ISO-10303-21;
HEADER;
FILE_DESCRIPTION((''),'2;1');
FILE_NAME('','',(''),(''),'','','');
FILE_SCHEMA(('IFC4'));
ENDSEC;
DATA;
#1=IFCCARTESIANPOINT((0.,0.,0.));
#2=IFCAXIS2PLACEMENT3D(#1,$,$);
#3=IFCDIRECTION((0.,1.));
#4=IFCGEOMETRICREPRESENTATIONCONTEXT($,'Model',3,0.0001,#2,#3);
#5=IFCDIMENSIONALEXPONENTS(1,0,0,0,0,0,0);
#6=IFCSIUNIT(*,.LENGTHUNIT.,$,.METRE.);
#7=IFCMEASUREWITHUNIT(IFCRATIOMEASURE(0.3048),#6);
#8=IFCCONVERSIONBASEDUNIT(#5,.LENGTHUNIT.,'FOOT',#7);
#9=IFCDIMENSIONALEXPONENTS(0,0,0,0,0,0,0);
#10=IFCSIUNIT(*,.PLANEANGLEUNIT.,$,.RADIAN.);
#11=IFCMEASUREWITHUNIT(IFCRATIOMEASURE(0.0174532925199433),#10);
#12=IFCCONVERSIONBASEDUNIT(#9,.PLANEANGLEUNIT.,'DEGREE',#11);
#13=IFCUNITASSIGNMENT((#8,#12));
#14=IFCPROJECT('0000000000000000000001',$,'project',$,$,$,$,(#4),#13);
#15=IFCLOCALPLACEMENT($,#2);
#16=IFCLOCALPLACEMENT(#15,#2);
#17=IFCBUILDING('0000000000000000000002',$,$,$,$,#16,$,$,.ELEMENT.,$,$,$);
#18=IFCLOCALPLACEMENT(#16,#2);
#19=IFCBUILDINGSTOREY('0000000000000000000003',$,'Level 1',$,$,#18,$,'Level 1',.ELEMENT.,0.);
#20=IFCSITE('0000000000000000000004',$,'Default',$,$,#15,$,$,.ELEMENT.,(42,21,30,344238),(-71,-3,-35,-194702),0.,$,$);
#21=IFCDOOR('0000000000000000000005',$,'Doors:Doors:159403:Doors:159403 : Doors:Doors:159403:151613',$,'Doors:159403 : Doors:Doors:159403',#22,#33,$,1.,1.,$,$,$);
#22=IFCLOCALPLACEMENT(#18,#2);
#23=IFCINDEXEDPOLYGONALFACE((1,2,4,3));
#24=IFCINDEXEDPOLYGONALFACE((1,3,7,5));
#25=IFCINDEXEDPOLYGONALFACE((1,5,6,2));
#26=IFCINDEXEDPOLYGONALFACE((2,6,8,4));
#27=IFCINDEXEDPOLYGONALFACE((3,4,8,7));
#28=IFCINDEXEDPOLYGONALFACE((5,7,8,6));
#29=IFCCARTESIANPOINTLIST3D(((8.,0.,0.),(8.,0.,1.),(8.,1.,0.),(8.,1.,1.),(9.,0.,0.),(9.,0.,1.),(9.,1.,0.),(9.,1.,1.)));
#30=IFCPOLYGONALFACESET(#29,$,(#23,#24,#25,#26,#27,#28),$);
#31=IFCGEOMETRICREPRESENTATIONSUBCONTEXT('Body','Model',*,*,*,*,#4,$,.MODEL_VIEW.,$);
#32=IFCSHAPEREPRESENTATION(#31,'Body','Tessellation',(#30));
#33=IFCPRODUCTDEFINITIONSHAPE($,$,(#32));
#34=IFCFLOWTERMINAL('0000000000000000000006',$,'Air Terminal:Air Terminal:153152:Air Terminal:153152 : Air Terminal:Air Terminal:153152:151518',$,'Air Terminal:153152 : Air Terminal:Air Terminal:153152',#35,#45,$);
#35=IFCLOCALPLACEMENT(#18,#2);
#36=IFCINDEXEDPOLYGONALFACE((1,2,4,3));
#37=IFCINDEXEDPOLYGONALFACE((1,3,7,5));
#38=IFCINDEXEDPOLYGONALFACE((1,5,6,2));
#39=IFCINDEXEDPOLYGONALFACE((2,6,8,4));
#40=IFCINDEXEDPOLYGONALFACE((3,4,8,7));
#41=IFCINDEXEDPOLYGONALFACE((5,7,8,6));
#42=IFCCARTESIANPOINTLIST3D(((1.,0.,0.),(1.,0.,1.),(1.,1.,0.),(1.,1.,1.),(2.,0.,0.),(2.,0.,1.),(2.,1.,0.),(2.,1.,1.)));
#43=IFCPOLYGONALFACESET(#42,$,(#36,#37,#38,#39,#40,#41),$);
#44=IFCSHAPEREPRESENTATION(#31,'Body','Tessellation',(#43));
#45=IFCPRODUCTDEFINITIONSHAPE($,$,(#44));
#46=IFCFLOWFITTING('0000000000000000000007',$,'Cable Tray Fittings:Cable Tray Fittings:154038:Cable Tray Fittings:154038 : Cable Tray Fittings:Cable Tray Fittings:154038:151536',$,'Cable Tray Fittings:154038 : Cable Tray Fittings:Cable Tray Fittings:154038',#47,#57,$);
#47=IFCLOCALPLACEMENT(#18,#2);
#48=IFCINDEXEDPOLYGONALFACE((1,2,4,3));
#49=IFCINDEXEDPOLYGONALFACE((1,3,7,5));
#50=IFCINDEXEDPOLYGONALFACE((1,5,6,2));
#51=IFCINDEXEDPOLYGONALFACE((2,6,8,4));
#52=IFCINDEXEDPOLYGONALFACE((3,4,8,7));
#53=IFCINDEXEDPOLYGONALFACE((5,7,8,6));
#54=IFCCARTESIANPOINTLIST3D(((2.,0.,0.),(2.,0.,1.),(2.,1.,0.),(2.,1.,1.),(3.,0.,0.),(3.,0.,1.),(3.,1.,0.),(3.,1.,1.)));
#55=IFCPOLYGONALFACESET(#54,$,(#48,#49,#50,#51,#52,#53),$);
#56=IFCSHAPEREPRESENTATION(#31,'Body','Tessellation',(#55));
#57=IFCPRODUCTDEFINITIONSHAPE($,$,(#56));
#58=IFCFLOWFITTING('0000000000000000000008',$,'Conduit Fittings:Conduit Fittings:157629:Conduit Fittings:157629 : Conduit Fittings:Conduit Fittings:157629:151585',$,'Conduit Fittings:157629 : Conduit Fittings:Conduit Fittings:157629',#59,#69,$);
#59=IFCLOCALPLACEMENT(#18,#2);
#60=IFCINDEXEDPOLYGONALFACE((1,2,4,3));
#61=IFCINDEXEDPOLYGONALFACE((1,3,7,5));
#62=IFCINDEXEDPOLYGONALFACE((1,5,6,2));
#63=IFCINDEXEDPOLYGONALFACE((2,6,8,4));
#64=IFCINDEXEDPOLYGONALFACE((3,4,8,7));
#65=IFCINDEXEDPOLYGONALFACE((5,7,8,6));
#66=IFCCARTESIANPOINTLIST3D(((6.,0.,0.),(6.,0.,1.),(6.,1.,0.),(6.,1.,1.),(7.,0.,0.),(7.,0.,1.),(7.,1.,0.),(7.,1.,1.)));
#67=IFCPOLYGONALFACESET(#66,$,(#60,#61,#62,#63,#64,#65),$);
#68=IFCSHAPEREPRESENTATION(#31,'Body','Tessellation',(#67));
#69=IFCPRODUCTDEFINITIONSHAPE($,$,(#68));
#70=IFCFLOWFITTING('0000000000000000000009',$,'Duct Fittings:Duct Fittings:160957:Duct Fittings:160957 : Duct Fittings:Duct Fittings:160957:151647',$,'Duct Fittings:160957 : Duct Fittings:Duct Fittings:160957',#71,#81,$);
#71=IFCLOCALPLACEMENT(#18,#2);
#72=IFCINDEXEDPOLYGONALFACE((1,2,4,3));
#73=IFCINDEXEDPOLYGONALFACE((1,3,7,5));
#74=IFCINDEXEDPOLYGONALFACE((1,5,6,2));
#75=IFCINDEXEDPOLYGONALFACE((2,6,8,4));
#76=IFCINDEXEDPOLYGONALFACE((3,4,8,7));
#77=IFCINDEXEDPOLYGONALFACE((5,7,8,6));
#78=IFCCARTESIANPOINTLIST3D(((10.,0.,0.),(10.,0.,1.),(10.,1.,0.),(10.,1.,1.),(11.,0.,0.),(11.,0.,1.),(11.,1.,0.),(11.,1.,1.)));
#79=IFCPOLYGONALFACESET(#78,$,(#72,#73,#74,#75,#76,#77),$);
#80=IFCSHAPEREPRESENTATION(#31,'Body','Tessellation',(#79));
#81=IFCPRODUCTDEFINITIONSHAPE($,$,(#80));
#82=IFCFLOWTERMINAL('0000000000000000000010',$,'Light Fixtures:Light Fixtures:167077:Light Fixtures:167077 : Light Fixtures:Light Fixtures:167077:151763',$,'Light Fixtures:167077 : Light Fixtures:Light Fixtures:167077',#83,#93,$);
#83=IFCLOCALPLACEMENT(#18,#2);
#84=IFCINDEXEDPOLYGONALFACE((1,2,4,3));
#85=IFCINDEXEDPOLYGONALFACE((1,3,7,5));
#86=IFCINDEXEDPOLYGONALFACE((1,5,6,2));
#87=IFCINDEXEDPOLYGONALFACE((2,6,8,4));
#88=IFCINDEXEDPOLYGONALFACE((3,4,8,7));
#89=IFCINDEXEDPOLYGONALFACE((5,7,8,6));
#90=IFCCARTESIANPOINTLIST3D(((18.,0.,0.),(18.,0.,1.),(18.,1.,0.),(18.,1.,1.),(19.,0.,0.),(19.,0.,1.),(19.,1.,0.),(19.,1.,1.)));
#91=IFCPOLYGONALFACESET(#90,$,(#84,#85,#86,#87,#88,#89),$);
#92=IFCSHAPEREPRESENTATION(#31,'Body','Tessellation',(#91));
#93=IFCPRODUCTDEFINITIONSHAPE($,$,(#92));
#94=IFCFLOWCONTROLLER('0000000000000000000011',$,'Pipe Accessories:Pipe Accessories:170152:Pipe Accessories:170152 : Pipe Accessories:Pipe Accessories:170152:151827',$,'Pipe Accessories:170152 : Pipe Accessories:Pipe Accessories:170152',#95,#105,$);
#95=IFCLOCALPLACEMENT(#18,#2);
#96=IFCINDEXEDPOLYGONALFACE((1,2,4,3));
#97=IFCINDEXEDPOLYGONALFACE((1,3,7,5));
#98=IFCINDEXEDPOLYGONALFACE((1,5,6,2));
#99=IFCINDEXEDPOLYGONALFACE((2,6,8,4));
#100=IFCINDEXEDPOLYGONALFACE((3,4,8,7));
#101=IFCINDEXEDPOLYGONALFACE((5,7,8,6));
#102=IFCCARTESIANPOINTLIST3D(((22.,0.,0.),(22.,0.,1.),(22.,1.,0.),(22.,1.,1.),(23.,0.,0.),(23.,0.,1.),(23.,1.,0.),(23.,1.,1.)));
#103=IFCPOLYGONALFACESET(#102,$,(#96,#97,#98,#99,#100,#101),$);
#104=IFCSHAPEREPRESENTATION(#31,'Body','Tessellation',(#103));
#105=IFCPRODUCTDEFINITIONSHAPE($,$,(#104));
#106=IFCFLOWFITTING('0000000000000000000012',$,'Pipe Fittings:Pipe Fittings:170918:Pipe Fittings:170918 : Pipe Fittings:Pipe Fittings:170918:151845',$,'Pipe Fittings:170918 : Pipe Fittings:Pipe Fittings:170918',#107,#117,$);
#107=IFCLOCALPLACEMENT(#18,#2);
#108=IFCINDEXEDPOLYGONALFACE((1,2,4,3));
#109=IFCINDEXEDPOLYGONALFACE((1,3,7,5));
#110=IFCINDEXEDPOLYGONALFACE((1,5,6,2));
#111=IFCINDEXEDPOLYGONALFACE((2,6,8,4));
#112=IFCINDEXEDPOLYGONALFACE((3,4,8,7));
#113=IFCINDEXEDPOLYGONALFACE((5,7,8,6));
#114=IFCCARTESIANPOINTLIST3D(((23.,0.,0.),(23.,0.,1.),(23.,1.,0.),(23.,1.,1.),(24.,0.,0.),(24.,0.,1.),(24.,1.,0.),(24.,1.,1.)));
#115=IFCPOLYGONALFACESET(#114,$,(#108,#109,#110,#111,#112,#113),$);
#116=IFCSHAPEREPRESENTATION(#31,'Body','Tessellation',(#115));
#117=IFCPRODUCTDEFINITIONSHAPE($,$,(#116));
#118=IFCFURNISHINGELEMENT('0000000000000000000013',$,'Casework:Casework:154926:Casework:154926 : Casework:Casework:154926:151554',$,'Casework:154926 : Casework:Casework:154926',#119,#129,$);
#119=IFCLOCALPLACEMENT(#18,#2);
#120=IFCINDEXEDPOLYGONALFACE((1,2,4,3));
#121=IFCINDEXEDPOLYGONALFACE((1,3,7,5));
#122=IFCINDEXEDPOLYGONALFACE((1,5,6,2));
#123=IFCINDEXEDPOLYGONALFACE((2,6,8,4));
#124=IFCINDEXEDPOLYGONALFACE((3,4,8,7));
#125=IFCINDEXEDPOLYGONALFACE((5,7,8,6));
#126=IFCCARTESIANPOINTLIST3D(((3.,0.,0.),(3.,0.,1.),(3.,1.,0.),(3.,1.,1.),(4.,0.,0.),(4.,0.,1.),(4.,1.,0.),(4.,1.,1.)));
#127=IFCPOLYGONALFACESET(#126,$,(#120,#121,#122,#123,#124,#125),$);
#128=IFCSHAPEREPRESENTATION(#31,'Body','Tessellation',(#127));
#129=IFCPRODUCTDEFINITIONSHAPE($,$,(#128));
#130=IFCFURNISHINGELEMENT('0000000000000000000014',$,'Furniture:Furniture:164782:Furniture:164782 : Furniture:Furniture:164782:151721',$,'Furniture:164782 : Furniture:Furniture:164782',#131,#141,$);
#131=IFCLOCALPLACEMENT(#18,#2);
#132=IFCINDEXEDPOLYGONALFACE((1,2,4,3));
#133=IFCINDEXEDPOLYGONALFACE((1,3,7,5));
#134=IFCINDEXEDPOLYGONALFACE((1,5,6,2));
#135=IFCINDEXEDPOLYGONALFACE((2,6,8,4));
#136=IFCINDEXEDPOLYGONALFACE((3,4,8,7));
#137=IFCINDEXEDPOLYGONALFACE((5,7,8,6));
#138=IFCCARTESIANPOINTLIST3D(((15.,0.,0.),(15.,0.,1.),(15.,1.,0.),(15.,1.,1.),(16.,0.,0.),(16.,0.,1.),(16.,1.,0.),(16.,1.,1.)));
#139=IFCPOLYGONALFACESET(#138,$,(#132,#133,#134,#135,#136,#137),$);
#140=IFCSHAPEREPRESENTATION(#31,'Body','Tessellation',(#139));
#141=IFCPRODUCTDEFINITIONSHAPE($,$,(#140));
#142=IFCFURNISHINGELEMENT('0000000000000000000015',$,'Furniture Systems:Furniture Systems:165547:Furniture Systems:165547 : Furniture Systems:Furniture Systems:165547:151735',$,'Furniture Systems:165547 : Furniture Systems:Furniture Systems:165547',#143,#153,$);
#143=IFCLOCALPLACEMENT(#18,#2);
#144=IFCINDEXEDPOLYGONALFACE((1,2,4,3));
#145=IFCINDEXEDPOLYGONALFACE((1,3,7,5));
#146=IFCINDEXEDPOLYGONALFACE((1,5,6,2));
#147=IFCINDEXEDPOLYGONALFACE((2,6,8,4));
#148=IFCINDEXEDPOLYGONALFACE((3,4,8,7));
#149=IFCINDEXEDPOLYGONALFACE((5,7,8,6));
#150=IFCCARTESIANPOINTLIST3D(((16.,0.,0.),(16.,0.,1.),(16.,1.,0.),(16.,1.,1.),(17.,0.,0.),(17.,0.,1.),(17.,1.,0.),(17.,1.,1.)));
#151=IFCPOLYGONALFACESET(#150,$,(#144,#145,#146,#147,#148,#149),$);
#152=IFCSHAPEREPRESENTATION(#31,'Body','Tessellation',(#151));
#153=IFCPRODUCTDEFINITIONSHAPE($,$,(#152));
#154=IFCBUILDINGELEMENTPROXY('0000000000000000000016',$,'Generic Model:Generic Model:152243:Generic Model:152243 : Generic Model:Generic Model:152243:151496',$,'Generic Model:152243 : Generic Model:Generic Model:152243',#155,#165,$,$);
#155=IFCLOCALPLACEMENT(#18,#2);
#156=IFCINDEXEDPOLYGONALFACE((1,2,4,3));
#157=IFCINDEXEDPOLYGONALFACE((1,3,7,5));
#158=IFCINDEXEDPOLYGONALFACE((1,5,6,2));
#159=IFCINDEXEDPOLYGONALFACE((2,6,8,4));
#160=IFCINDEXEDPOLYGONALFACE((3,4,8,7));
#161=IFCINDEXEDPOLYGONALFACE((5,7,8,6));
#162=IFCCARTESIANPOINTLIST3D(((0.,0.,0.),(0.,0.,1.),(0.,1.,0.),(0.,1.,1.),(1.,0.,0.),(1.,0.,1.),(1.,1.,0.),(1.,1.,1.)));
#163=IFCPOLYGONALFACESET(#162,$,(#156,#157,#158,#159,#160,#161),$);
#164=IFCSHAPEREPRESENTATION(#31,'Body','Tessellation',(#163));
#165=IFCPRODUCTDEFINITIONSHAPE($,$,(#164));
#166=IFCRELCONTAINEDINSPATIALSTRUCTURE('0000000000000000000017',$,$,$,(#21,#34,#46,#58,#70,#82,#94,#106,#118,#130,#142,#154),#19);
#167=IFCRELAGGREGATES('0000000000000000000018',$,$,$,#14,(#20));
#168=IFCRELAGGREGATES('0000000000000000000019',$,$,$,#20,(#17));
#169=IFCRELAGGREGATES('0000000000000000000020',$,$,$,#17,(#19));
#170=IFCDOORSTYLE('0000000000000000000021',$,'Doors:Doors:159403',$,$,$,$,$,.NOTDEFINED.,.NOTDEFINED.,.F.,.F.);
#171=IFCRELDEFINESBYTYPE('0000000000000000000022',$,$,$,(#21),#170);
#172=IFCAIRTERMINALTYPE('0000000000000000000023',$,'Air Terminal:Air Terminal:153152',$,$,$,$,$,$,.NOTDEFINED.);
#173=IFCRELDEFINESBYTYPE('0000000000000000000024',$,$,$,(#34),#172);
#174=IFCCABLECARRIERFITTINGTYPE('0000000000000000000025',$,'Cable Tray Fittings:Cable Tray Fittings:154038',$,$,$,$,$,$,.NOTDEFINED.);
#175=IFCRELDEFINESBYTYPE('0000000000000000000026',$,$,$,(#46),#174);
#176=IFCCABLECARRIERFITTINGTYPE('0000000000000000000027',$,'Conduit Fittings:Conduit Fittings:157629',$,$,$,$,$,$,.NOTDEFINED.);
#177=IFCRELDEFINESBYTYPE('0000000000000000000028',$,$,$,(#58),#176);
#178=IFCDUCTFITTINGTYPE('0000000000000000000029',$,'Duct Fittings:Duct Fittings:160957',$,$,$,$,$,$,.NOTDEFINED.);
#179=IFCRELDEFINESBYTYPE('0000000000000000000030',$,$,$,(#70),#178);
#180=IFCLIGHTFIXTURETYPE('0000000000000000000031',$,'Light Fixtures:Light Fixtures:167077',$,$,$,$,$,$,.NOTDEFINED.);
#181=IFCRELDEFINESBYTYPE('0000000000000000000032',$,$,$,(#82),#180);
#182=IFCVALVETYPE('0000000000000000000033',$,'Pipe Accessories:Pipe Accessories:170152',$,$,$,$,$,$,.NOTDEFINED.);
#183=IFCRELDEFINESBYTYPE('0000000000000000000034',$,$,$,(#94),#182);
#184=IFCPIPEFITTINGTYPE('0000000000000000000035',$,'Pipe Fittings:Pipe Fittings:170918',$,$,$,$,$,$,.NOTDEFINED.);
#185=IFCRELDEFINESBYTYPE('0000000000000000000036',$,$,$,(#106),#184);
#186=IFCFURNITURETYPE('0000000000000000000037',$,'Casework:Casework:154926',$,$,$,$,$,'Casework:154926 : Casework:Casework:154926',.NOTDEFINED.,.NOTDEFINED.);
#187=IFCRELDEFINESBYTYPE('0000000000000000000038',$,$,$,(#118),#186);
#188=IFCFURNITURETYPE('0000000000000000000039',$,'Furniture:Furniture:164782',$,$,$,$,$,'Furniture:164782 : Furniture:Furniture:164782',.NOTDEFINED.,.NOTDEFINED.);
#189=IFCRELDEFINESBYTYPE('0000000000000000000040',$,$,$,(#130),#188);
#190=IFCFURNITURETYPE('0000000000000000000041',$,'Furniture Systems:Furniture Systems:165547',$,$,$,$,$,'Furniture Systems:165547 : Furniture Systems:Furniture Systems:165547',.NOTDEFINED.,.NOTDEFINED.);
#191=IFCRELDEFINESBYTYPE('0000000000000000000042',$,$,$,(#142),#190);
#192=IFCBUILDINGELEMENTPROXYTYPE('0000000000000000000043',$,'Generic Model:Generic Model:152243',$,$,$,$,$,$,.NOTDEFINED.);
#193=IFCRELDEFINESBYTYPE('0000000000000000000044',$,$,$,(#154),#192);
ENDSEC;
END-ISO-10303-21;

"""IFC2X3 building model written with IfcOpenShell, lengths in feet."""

from ifc_helpers import new_model, entity, si_unit, converted_unit, direction, frame, frame_2d, origin, origin_2d_with_axis, place, context, subcontext, project, spatial, rectangle, extrude, source, transform, mapped, type_object, type_shapes, element, save


model = new_model("IFC2X3")

# Units and contexts
model_context = context("Model", 3, precision=0.0001, world=origin(), true_north=direction((0.0, 1.0)))
body_context = subcontext(model_context, "Body", "Model", "MODEL_VIEW")
ifc_project = project(units=[converted_unit("LENGTHUNIT", "FOOT", entity("IfcRatioMeasure", 0.3048), si_unit("LENGTHUNIT", "METRE"), dimensions=[1, 0, 0, 0, 0, 0, 0]), converted_unit("PLANEANGLEUNIT", "DEGREE", entity("IfcRatioMeasure", 0.0174532925199433), si_unit("PLANEANGLEUNIT", "RADIAN"), dimensions=[0, 0, 0, 0, 0, 0, 0])], contexts=[model_context])

# Site, building, storey
site_placement = place(None, origin())
site = spatial("IfcSite", under=ifc_project, at=site_placement, Name="Default", CompositionType="ELEMENT", RefLatitude=(42, 21, 30, 344238), RefLongitude=(-71, -3, -35, -194702), RefElevation=0.0)
building_placement = place(site_placement, origin())
building = spatial("IfcBuilding", under=site, at=building_placement, CompositionType="ELEMENT")
storey_placement = place(building_placement, origin())
storey = spatial("IfcBuildingStorey", under=building, at=storey_placement, Name="Level 1", LongName="Level 1", CompositionType="ELEMENT", Elevation=0.0)

# Door
door_style = type_object("IfcDoorStyle", Name="Doors:Doors:159403", ConstructionType="NOTDEFINED", OperationType="NOTDEFINED", ParameterTakesPrecedence=False, Sizeable=False)
shared_shape_1 = source(origin(), body_context, "Body", "SweptSolid", [
    extrude(rectangle(XDim=1.0, YDim=1.0, at=origin_2d_with_axis()), frame((8.5, 0.5, 0.0), z_axis=(0.0, 0.0, 1.0), x_axis=(-1.0, 0.0, 0.0)), (0.0, 0.0, 1.0), 1.0),
])
type_shapes(door_style, [shared_shape_1])
door_placement = place(storey_placement, origin())
element("IfcDoor", 1, at=door_placement, inside=storey, type_object=door_style, Name="Doors:Doors:159403:Doors:159403 : Doors:Doors:159403:151613", ObjectType="Doors:159403 : Doors:Doors:159403", OverallHeight=1.0, OverallWidth=1.0, context=body_context, shape_type="MappedRepresentation", body=[
    mapped(shared_shape_1, transform((0.0, 0.0, 0.0), scale=1.0)),
])

# Flow terminal
air_terminal_type = type_object("IfcAirTerminalType", Name="Air Terminal:Air Terminal:153152", PredefinedType="NOTDEFINED")
shared_shape_2 = source(origin(), body_context, "Body", "SweptSolid", [
    extrude(rectangle(XDim=1.0, YDim=1.0, at=frame_2d((0.0, 0.0), x_axis=(1.0, 0.0))), frame((1.5, 0.5, 0.0), z_axis=(0.0, 0.0, 1.0), x_axis=(-1.0, 0.0, 0.0)), (0.0, 0.0, 1.0), 1.0),
])
type_shapes(air_terminal_type, [shared_shape_2])
flow_terminal_1_placement = place(storey_placement, origin())
element("IfcFlowTerminal", 2, at=flow_terminal_1_placement, inside=storey, type_object=air_terminal_type, Name="Air Terminal:Air Terminal:153152:Air Terminal:153152 : Air Terminal:Air Terminal:153152:151518", ObjectType="Air Terminal:153152 : Air Terminal:Air Terminal:153152", context=body_context, shape_type="MappedRepresentation", body=[
    mapped(shared_shape_2, transform((0.0, 0.0, 0.0), scale=1.0)),
])

# Flow fittings
cable_carrier_fitting_type_1 = type_object("IfcCableCarrierFittingType", Name="Cable Tray Fittings:Cable Tray Fittings:154038", PredefinedType="NOTDEFINED")
shared_shape_3 = source(origin(), body_context, "Body", "SweptSolid", [
    extrude(rectangle(XDim=1.0, YDim=1.0, at=origin_2d_with_axis()), frame((2.5, 0.5, 0.0), z_axis=(0.0, 0.0, 1.0), x_axis=(-1.0, 0.0, 0.0)), (0.0, 0.0, 1.0), 1.0),
])
type_shapes(cable_carrier_fitting_type_1, [shared_shape_3])
flow_fitting_1_placement = place(storey_placement, origin())
element("IfcFlowFitting", 3, at=flow_fitting_1_placement, inside=storey, type_object=cable_carrier_fitting_type_1, Name="Cable Tray Fittings:Cable Tray Fittings:154038:Cable Tray Fittings:154038 : Cable Tray Fittings:Cable Tray Fittings:154038:151536", ObjectType="Cable Tray Fittings:154038 : Cable Tray Fittings:Cable Tray Fittings:154038", context=body_context, shape_type="MappedRepresentation", body=[
    mapped(shared_shape_3, transform((0.0, 0.0, 0.0), scale=1.0)),
])
cable_carrier_fitting_type_2 = type_object("IfcCableCarrierFittingType", Name="Conduit Fittings:Conduit Fittings:157629", PredefinedType="NOTDEFINED")
shared_shape_4 = source(origin(), body_context, "Body", "SweptSolid", [
    extrude(rectangle(XDim=1.0, YDim=1.0, at=frame_2d((0.0, 0.0), x_axis=(1.0, 0.0))), frame((6.5, 0.5, 0.0), z_axis=(0.0, 0.0, 1.0), x_axis=(-1.0, 0.0, 0.0)), (0.0, 0.0, 1.0), 1.0),
])
type_shapes(cable_carrier_fitting_type_2, [shared_shape_4])
flow_fitting_2_placement = place(storey_placement, origin())
element("IfcFlowFitting", 4, at=flow_fitting_2_placement, inside=storey, type_object=cable_carrier_fitting_type_2, Name="Conduit Fittings:Conduit Fittings:157629:Conduit Fittings:157629 : Conduit Fittings:Conduit Fittings:157629:151585", ObjectType="Conduit Fittings:157629 : Conduit Fittings:Conduit Fittings:157629", context=body_context, shape_type="MappedRepresentation", body=[
    mapped(shared_shape_4, transform((0.0, 0.0, 0.0), scale=1.0)),
])
duct_fitting_type = type_object("IfcDuctFittingType", Name="Duct Fittings:Duct Fittings:160957", PredefinedType="NOTDEFINED")
shared_shape_5 = source(origin(), body_context, "Body", "SweptSolid", [
    extrude(rectangle(XDim=1.0, YDim=1.0, at=origin_2d_with_axis()), frame((10.5, 0.5, 0.0), z_axis=(0.0, 0.0, 1.0), x_axis=(-1.0, 0.0, 0.0)), (0.0, 0.0, 1.0), 1.0),
])
type_shapes(duct_fitting_type, [shared_shape_5])
flow_fitting_3_placement = place(storey_placement, origin())
element("IfcFlowFitting", 5, at=flow_fitting_3_placement, inside=storey, type_object=duct_fitting_type, Name="Duct Fittings:Duct Fittings:160957:Duct Fittings:160957 : Duct Fittings:Duct Fittings:160957:151647", ObjectType="Duct Fittings:160957 : Duct Fittings:Duct Fittings:160957", context=body_context, shape_type="MappedRepresentation", body=[
    mapped(shared_shape_5, transform((0.0, 0.0, 0.0), scale=1.0)),
])

# Flow terminal
light_fixture_type = type_object("IfcLightFixtureType", Name="Light Fixtures:Light Fixtures:167077", PredefinedType="NOTDEFINED")
shared_shape_6 = source(origin(), body_context, "Body", "SweptSolid", [
    extrude(rectangle(XDim=1.0, YDim=1.0, at=origin_2d_with_axis()), frame((18.5, 0.5, 0.0), z_axis=(0.0, 0.0, 1.0), x_axis=(-1.0, 0.0, 0.0)), (0.0, 0.0, 1.0), 1.0),
])
type_shapes(light_fixture_type, [shared_shape_6])
flow_terminal_2_placement = place(storey_placement, origin())
element("IfcFlowTerminal", 6, at=flow_terminal_2_placement, inside=storey, type_object=light_fixture_type, Name="Light Fixtures:Light Fixtures:167077:Light Fixtures:167077 : Light Fixtures:Light Fixtures:167077:151763", ObjectType="Light Fixtures:167077 : Light Fixtures:Light Fixtures:167077", context=body_context, shape_type="MappedRepresentation", body=[
    mapped(shared_shape_6, transform((0.0, 0.0, 0.0), scale=1.0)),
])

# Flow controller
valve_type = type_object("IfcValveType", Name="Pipe Accessories:Pipe Accessories:170152", PredefinedType="NOTDEFINED")
shared_shape_7 = source(origin(), body_context, "Body", "SweptSolid", [
    extrude(rectangle(XDim=1.0, YDim=1.0, at=origin_2d_with_axis()), frame((22.5, 0.5, 0.0), z_axis=(0.0, 0.0, 1.0), x_axis=(-1.0, 0.0, 0.0)), (0.0, 0.0, 1.0), 1.0),
])
type_shapes(valve_type, [shared_shape_7])
flow_controller_placement = place(storey_placement, origin())
element("IfcFlowController", 7, at=flow_controller_placement, inside=storey, type_object=valve_type, Name="Pipe Accessories:Pipe Accessories:170152:Pipe Accessories:170152 : Pipe Accessories:Pipe Accessories:170152:151827", ObjectType="Pipe Accessories:170152 : Pipe Accessories:Pipe Accessories:170152", context=body_context, shape_type="MappedRepresentation", body=[
    mapped(shared_shape_7, transform((0.0, 0.0, 0.0), scale=1.0)),
])

# Flow fitting
pipe_fitting_type = type_object("IfcPipeFittingType", Name="Pipe Fittings:Pipe Fittings:170918", PredefinedType="NOTDEFINED")
shared_shape_8 = source(origin(), body_context, "Body", "SweptSolid", [
    extrude(rectangle(XDim=1.0, YDim=1.0, at=origin_2d_with_axis()), frame((23.5, 0.5, 0.0), z_axis=(0.0, 0.0, 1.0), x_axis=(-1.0, 0.0, 0.0)), (0.0, 0.0, 1.0), 1.0),
])
type_shapes(pipe_fitting_type, [shared_shape_8])
flow_fitting_4_placement = place(storey_placement, origin())
element("IfcFlowFitting", 8, at=flow_fitting_4_placement, inside=storey, type_object=pipe_fitting_type, Name="Pipe Fittings:Pipe Fittings:170918:Pipe Fittings:170918 : Pipe Fittings:Pipe Fittings:170918:151845", ObjectType="Pipe Fittings:170918 : Pipe Fittings:Pipe Fittings:170918", context=body_context, shape_type="MappedRepresentation", body=[
    mapped(shared_shape_8, transform((0.0, 0.0, 0.0), scale=1.0)),
])

# Furnishing elements
furniture_type_1 = type_object("IfcFurnitureType", Name="Casework:Casework:154926", ElementType="Casework:154926 : Casework:Casework:154926")
shared_shape_9 = source(origin(), body_context, "Body", "SweptSolid", [
    extrude(rectangle(XDim=1.0, YDim=1.0, at=frame_2d((0.0, 0.0), x_axis=(1.0, 0.0))), frame((3.5, 0.5, 0.0), z_axis=(0.0, 0.0, 1.0), x_axis=(-1.0, 0.0, 0.0)), (0.0, 0.0, 1.0), 1.0),
])
type_shapes(furniture_type_1, [shared_shape_9])
furnishing_1_placement = place(storey_placement, origin())
element("IfcFurnishingElement", 9, at=furnishing_1_placement, inside=storey, type_object=furniture_type_1, Name="Casework:Casework:154926:Casework:154926 : Casework:Casework:154926:151554", ObjectType="Casework:154926 : Casework:Casework:154926", context=body_context, shape_type="MappedRepresentation", body=[
    mapped(shared_shape_9, transform((0.0, 0.0, 0.0), scale=1.0)),
])
furniture_type_2 = type_object("IfcFurnitureType", Name="Furniture:Furniture:164782", ElementType="Furniture:164782 : Furniture:Furniture:164782")
shared_shape_10 = source(origin(), body_context, "Body", "SweptSolid", [
    extrude(rectangle(XDim=1.0, YDim=1.0, at=frame_2d((0.0, 0.0), x_axis=(1.0, 0.0))), frame((15.5, 0.5, 0.0), z_axis=(0.0, 0.0, 1.0), x_axis=(-1.0, 0.0, 0.0)), (0.0, 0.0, 1.0), 1.0),
])
type_shapes(furniture_type_2, [shared_shape_10])
furnishing_2_placement = place(storey_placement, origin())
element("IfcFurnishingElement", 10, at=furnishing_2_placement, inside=storey, type_object=furniture_type_2, Name="Furniture:Furniture:164782:Furniture:164782 : Furniture:Furniture:164782:151721", ObjectType="Furniture:164782 : Furniture:Furniture:164782", context=body_context, shape_type="MappedRepresentation", body=[
    mapped(shared_shape_10, transform((0.0, 0.0, 0.0), scale=1.0)),
])
furniture_type_3 = type_object("IfcFurnitureType", Name="Furniture Systems:Furniture Systems:165547", ElementType="Furniture Systems:165547 : Furniture Systems:Furniture Systems:165547")
shared_shape_11 = source(origin(), body_context, "Body", "SweptSolid", [
    extrude(rectangle(XDim=1.0, YDim=1.0, at=origin_2d_with_axis()), frame((16.5, 0.5, 0.0), z_axis=(0.0, 0.0, 1.0), x_axis=(-1.0, 0.0, 0.0)), (0.0, 0.0, 1.0), 1.0),
])
type_shapes(furniture_type_3, [shared_shape_11])
furnishing_3_placement = place(storey_placement, origin())
element("IfcFurnishingElement", 11, at=furnishing_3_placement, inside=storey, type_object=furniture_type_3, Name="Furniture Systems:Furniture Systems:165547:Furniture Systems:165547 : Furniture Systems:Furniture Systems:165547:151735", ObjectType="Furniture Systems:165547 : Furniture Systems:Furniture Systems:165547", context=body_context, shape_type="MappedRepresentation", body=[
    mapped(shared_shape_11, transform((0.0, 0.0, 0.0), scale=1.0)),
])

# Building element proxy
building_element_proxy_type_1 = type_object("IfcBuildingElementProxyType", Name="Generic Model:Generic Model:152243", PredefinedType="NOTDEFINED")
shared_shape_12 = source(origin(), body_context, "Body", "SweptSolid", [
    extrude(rectangle(XDim=1.0, YDim=1.0, at=frame_2d((0.0, 0.0), x_axis=(1.0, 0.0))), frame((0.5, 0.5, 0.0), z_axis=(0.0, 0.0, 1.0), x_axis=(-1.0, 0.0, 0.0)), (0.0, 0.0, 1.0), 1.0),
])
type_shapes(building_element_proxy_type_1, [shared_shape_12])
proxy_1_placement = place(storey_placement, origin())
element("IfcBuildingElementProxy", 12, at=proxy_1_placement, inside=storey, type_object=building_element_proxy_type_1, Name="Generic Model:Generic Model:152243:Generic Model:152243 : Generic Model:Generic Model:152243:151496", ObjectType="Generic Model:152243 : Generic Model:Generic Model:152243", context=body_context, shape_type="MappedRepresentation", body=[
    mapped(shared_shape_12, transform((0.0, 0.0, 0.0), scale=1.0)),
])

save(model, "model.ifc")
